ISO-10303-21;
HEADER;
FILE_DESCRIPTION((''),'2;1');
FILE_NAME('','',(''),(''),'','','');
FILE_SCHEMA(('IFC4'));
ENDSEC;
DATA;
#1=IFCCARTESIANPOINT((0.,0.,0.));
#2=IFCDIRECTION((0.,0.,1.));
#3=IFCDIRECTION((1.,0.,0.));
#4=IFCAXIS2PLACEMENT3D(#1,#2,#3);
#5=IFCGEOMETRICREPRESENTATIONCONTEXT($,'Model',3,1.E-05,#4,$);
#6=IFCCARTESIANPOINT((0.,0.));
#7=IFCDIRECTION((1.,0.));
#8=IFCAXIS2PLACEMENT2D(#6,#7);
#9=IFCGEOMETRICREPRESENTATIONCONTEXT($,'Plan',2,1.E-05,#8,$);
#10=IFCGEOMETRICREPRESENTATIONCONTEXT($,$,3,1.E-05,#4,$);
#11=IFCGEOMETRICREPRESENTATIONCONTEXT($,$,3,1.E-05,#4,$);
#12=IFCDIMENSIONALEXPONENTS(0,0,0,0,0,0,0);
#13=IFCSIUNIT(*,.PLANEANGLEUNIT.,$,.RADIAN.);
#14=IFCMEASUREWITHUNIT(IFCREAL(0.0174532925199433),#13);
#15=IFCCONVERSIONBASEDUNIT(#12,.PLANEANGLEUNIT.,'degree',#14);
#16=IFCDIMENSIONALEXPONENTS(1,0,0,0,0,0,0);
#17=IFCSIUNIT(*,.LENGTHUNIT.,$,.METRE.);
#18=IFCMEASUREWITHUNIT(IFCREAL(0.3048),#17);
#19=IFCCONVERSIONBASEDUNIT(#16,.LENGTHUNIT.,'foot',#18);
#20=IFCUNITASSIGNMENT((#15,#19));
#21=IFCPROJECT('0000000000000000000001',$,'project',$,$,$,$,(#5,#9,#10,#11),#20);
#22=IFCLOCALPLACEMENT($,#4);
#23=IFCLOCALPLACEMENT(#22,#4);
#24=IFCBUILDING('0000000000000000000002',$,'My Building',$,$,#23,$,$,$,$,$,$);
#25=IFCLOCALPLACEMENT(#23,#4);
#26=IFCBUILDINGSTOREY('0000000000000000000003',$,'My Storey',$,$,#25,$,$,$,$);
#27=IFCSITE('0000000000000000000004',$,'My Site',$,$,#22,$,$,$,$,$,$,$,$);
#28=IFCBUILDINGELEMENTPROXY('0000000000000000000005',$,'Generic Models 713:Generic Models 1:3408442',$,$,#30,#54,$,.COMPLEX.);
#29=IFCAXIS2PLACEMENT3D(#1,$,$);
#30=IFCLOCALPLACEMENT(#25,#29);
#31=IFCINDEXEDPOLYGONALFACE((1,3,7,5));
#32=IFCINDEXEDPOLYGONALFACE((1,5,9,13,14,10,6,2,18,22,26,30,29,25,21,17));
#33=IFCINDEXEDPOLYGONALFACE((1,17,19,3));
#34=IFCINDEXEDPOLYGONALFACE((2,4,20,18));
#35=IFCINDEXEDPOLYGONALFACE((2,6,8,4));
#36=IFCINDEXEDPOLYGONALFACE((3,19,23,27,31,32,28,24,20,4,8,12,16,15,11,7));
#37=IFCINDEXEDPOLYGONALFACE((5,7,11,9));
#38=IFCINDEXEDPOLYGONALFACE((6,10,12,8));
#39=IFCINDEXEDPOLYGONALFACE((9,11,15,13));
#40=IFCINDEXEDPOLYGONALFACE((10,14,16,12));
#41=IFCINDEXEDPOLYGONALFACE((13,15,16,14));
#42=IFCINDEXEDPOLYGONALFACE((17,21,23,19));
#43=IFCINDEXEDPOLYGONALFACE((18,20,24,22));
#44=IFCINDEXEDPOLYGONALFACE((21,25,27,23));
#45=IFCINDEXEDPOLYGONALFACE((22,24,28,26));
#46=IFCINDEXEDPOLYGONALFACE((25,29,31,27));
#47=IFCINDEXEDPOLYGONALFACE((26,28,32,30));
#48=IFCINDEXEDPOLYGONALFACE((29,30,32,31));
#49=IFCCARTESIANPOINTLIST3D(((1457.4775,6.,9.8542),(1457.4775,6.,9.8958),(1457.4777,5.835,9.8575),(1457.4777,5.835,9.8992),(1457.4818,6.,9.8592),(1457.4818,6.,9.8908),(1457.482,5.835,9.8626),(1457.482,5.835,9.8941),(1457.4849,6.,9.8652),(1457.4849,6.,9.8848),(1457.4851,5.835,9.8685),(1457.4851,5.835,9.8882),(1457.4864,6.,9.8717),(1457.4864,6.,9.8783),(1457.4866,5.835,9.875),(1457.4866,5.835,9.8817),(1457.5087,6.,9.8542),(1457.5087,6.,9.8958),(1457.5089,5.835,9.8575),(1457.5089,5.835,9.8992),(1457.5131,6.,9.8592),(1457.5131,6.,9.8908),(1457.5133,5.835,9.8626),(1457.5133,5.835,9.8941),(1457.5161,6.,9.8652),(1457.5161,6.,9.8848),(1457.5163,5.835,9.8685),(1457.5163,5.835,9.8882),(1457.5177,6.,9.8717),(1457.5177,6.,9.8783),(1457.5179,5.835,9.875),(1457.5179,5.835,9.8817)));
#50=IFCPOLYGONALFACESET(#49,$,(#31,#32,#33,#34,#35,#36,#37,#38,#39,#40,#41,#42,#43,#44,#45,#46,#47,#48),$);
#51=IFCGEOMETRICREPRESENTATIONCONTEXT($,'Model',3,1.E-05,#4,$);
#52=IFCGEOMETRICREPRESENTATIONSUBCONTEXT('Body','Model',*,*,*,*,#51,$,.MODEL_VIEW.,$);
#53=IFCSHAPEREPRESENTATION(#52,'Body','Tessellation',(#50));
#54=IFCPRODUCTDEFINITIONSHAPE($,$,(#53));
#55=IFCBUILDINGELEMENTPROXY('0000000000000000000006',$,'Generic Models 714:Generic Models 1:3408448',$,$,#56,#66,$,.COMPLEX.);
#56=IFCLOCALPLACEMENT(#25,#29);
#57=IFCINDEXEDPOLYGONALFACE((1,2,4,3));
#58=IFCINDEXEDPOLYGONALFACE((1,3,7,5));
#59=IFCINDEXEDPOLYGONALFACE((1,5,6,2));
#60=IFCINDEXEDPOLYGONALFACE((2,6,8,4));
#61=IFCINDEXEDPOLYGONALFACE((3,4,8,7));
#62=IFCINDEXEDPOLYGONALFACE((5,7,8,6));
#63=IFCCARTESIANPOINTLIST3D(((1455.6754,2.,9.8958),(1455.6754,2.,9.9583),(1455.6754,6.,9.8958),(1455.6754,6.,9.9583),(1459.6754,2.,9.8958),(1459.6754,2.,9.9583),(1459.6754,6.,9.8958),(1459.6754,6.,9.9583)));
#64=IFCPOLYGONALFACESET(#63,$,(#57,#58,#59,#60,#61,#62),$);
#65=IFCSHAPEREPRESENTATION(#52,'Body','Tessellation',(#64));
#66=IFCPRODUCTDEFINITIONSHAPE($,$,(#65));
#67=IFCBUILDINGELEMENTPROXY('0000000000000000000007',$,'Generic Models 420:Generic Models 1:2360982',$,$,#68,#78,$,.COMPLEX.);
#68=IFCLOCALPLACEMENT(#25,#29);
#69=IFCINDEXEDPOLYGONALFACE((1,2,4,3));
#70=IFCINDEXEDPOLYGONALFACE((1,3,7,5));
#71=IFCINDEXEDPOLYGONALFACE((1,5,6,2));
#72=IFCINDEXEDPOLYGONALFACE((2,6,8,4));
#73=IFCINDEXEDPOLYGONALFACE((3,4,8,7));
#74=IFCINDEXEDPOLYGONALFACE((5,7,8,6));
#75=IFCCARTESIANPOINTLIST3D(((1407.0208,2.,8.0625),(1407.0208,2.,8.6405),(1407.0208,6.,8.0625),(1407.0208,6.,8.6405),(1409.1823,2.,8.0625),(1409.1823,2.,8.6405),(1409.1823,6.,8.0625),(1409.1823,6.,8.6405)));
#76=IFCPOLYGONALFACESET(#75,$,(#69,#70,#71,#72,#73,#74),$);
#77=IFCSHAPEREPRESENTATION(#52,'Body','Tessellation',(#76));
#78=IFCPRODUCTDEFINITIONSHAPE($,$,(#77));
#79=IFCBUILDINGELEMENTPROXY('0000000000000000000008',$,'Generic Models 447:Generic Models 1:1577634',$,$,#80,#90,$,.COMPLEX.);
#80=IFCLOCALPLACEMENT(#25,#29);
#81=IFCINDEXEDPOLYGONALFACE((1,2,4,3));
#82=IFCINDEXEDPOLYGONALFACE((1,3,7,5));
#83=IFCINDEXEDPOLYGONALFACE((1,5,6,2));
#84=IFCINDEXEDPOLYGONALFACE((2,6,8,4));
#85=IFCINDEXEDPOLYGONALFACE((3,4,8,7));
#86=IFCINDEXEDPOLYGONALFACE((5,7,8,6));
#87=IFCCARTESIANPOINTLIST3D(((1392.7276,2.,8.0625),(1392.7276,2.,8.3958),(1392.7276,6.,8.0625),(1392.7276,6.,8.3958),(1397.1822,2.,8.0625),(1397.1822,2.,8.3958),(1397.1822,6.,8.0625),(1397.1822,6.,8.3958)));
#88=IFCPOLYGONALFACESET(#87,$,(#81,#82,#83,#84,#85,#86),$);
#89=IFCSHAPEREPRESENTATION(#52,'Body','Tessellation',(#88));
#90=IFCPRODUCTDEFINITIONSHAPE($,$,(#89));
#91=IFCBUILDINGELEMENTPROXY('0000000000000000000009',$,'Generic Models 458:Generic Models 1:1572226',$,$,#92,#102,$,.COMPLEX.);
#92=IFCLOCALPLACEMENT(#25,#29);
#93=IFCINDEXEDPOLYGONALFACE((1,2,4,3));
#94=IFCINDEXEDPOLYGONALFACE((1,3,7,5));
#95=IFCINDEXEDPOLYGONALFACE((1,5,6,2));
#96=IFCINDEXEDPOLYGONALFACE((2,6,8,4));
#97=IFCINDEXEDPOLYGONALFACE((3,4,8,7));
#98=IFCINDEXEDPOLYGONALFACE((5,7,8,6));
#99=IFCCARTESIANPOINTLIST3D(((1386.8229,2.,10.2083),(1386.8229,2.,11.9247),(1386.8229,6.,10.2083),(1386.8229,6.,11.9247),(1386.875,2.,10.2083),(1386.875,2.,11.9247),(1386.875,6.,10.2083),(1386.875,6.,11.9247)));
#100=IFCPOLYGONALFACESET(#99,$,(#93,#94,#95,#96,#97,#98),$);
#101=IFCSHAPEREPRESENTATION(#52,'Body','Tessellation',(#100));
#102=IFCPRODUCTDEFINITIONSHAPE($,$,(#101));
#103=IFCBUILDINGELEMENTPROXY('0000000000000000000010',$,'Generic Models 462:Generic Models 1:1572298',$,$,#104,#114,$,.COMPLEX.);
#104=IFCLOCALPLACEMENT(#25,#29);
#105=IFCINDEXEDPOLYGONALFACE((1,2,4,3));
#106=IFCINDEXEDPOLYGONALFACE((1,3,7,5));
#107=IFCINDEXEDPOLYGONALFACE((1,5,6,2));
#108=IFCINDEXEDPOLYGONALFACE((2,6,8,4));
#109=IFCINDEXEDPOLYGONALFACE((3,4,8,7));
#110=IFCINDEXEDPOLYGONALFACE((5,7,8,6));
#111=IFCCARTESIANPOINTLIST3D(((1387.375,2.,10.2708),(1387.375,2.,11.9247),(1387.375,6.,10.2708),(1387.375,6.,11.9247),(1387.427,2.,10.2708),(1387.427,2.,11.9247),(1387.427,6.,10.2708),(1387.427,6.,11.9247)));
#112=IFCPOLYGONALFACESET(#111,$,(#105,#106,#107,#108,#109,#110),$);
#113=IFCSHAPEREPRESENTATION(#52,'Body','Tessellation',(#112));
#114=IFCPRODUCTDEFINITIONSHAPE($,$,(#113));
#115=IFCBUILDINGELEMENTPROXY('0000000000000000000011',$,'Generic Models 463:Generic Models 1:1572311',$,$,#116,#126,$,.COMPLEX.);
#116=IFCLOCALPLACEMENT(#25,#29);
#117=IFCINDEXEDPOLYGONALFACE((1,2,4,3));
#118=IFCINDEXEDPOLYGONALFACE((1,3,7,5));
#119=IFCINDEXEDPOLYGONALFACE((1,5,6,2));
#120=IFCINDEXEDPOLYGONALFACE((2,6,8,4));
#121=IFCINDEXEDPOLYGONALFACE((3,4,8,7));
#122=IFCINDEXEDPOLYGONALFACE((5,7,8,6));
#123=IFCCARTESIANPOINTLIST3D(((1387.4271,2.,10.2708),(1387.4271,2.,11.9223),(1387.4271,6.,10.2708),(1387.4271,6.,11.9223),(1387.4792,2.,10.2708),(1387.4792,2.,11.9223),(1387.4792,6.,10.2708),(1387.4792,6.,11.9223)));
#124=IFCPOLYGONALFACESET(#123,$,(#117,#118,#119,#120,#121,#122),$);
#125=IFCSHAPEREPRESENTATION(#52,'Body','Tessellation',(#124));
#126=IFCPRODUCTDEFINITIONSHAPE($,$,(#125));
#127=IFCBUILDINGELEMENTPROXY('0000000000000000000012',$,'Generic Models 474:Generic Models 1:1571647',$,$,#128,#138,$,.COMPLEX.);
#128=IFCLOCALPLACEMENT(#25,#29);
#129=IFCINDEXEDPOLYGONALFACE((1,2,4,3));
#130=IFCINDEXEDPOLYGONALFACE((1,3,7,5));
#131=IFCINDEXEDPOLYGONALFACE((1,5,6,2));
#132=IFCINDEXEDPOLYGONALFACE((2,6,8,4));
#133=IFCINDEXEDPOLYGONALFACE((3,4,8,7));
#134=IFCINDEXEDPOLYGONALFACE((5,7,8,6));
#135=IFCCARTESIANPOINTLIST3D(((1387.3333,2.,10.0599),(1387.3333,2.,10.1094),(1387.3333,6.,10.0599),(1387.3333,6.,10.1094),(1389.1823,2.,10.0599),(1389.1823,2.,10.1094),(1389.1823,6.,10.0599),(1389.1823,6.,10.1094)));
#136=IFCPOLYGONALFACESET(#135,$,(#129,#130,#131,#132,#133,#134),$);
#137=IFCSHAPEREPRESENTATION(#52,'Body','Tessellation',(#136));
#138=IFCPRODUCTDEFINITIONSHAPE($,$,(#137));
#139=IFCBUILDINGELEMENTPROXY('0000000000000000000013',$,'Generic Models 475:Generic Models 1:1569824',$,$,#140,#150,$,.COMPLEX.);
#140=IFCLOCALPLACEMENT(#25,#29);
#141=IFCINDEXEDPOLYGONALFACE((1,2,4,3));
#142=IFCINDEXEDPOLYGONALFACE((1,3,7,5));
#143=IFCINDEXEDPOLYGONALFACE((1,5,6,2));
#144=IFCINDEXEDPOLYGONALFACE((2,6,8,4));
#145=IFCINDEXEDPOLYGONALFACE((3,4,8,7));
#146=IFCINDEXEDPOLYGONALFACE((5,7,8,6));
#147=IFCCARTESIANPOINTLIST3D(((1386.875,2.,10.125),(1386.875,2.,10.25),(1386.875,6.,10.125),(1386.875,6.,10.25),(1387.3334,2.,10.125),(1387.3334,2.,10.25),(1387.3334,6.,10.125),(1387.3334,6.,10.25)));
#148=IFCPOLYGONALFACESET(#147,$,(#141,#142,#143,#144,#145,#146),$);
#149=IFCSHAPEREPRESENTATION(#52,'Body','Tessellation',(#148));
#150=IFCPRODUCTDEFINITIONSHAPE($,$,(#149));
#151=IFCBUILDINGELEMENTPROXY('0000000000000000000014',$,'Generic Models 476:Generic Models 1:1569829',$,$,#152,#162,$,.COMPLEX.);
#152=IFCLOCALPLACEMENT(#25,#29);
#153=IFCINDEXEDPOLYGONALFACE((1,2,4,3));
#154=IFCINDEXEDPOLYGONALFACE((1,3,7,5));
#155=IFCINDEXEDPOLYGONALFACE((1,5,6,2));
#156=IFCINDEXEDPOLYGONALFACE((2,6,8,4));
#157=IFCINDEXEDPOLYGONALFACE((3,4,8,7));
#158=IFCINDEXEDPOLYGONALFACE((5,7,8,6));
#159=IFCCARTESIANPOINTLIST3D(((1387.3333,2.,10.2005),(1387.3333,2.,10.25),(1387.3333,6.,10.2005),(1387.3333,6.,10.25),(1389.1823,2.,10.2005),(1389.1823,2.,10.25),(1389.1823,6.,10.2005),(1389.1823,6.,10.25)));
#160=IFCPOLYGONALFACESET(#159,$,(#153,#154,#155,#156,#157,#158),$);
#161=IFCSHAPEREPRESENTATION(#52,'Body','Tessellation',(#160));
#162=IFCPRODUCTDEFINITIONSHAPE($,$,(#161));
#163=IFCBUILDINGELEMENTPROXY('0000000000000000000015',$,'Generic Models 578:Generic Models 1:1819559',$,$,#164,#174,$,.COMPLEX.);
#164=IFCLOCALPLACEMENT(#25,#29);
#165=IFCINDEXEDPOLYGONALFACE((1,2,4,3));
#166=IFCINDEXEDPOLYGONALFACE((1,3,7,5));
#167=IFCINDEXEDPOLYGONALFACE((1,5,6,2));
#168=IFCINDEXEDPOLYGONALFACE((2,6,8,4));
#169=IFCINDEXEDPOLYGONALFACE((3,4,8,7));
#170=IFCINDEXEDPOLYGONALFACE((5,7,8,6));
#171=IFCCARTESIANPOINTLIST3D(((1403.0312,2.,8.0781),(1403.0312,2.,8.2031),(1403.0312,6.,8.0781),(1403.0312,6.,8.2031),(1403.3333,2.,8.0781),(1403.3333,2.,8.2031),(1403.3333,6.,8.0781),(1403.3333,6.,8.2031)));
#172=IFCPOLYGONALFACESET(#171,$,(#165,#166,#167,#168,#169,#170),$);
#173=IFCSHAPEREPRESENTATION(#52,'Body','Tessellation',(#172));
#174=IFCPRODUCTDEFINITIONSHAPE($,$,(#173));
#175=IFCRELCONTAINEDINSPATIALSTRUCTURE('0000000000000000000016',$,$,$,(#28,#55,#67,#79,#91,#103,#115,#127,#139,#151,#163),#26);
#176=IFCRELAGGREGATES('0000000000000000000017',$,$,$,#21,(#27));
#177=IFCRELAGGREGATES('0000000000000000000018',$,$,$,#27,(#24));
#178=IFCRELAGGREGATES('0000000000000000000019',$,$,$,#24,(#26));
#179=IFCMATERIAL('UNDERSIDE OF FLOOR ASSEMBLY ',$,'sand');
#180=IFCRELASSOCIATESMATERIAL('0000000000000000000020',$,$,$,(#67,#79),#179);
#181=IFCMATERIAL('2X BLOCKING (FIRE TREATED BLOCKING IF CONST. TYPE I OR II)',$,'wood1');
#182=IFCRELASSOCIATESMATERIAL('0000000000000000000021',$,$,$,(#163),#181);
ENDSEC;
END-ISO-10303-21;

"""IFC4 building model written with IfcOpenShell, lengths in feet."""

from ifc_helpers import new_model, entity, si_unit, converted_unit, frame, origin_with_axes, origin_2d_with_axis, place, context, subcontext, project, spatial, polyline, line, indexed_curve, outline, extrude, material, element, save


model = new_model("IFC4")

# Units and contexts
model_context_1 = context("Model", 3, precision=1e-05, world=origin_with_axes())
plan_context = context("Plan", 2, precision=1e-05, world=origin_2d_with_axis())
model_context_2 = context("Model", 3, precision=1e-05, world=origin_with_axes())
context_of_model_1 = context(None, 3, precision=1e-05, world=origin_with_axes())
context_of_model_2 = context(None, 3, precision=1e-05, world=origin_with_axes())
body_context_1 = subcontext(model_context_2, "Body", "Model", "MODEL_VIEW")
ifc_project = project(units=[converted_unit("PLANEANGLEUNIT", "degree", entity("IfcReal", 0.0174532925199433), si_unit("PLANEANGLEUNIT", "RADIAN"), dimensions=[0, 0, 0, 0, 0, 0, 0]), converted_unit("LENGTHUNIT", "foot", entity("IfcReal", 0.3048), si_unit("LENGTHUNIT", "METRE"), dimensions=[1, 0, 0, 0, 0, 0, 0])], contexts=[model_context_1, plan_context, context_of_model_1, context_of_model_2])

# Site, building, storey
site_placement = place(None, origin_with_axes())
site = spatial("IfcSite", under=ifc_project, at=site_placement, Name="My Site")
building_placement = place(site_placement, origin_with_axes())
building = spatial("IfcBuilding", under=site, at=building_placement, Name="My Building")
storey_placement = place(building_placement, origin_with_axes())
storey = spatial("IfcBuildingStorey", under=building, at=storey_placement, Name="My Storey")

# Building element proxies
ifc_material_1 = material(Name="UNDERSIDE OF FLOOR ASSEMBLY ", Category="sand")
proxy_1_placement = place(storey_placement, frame((1457.4775, 6.0, 9.8542), z_axis=(0.0, -1.0, 0.0), x_axis=(0.0, 0.0, 1.0)))
element("IfcBuildingElementProxy", 1, at=proxy_1_placement, inside=storey, Name="Generic Models 713:Generic Models 1:3408442", PredefinedType="COMPLEX", context=body_context_1, shape_type="SweptSolid", body=[
    extrude(outline(polyline([(0.0166, 0.0), (0.0226, 0.003), (0.0291, 0.0045), (0.0039, 0.023), (-0.0026, 0.0215), (-0.0086, 0.0185), (-0.0137, 0.0142), (-0.0176, 0.0088), (-0.0202, 0.0026), (-0.0213, -0.004), (-0.0207, -0.0106), (0.0045, -0.0291), (0.0039, -0.0224), (0.005, -0.0159), (0.0076, -0.0097), (0.0115, -0.0043), (0.0166, 0.0)])), frame((0.0208, -0.0208, 0.0), z_axis=(0.0, 0.0, -1.0), x_axis=(0.591192, 0.806531, 0.0)), (0.010994, 0.017024, -0.999795), 0.165),
])
proxy_2_placement = place(storey_placement, frame((1455.6754, 6.0, 9.8958), z_axis=(0.0, -1.0, 0.0), x_axis=(0.0, 0.0, 1.0)))
element("IfcBuildingElementProxy", 2, at=proxy_2_placement, inside=storey, Name="Generic Models 714:Generic Models 1:3408448", PredefinedType="COMPLEX", context=body_context_1, shape_type="SweptSolid", body=[
    extrude(outline(indexed_curve([(-0.0313, -2.0), (0.0312, -2.0), (0.0313, 2.0), (-0.0312, 2.0)], segments=[line(4, 1), line(1, 2), line(2, 3), line(3, 4)], self_intersect=False)), frame((0.0313, -2.0, 0.0), z_axis=(0.0, 0.0, -1.0), x_axis=(-1.0, 0.0, 0.0)), (0.0, 0.0, -1.0), 4.0),
])
proxy_3_placement = place(storey_placement, frame((1407.0208, 6.0, 8.0625), z_axis=(0.0, -1.0, 0.0), x_axis=(0.0, 0.0, 1.0)))
element("IfcBuildingElementProxy", 3, at=proxy_3_placement, inside=storey, material=ifc_material_1, Name="Generic Models 420:Generic Models 1:2360982", PredefinedType="COMPLEX", context=body_context_1, shape_type="SweptSolid", body=[
    extrude(outline(polyline([(-0.289, -1.0807), (0.289, -1.0807), (0.289, 1.0807), (-0.289, 1.0807), (-0.289, -1.0807)])), frame((0.289, -1.0807, 0.0), z_axis=(0.0, 0.0, -1.0), x_axis=(1.0, 0.0, 0.0)), (0.0, 0.0, -1.0), 4.0),
])
proxy_4_placement = place(storey_placement, frame((1392.7276, 6.0, 8.0625), z_axis=(0.0, -1.0, 0.0), x_axis=(0.0, 0.0, 1.0)))
element("IfcBuildingElementProxy", 4, at=proxy_4_placement, inside=storey, material=ifc_material_1, Name="Generic Models 447:Generic Models 1:1577634", PredefinedType="COMPLEX", context=body_context_1, shape_type="SweptSolid", body=[
    extrude(outline(indexed_curve([(-2.4546, -0.1667), (2.0, -0.1667), (2.0, 0.1667), (-2.4546, 0.1667)], segments=[line(3, 2), line(2, 1), line(1, 4), line(4, 3)], self_intersect=False)), frame((0.1667, -2.0, 0.0), z_axis=(0.0, 0.0, -1.0), x_axis=(0.0, 1.0, 0.0)), (0.0, 0.0, -1.0), 4.0),
])
proxy_5_placement = place(storey_placement, frame((1386.8229, 6.0, 10.2083), z_axis=(0.0, -1.0, 0.0), x_axis=(0.0, 0.0, 1.0)))
element("IfcBuildingElementProxy", 5, at=proxy_5_placement, inside=storey, Name="Generic Models 458:Generic Models 1:1572226", PredefinedType="COMPLEX", context=body_context_1, shape_type="SweptSolid", body=[
    extrude(outline(polyline([(-0.8582, -0.026), (0.8582, -0.026), (0.8582, 0.026), (-0.8582, 0.026), (-0.8582, -0.026)])), frame((0.8582, -0.026, 0.0), z_axis=(0.0, 0.0, -1.0), x_axis=(1.0, 0.0, 0.0)), (0.0, 0.0, -1.0), 4.0),
])
proxy_6_placement = place(storey_placement, frame((1387.375, 6.0, 10.2708), z_axis=(0.0, -1.0, 0.0), x_axis=(0.0, 0.0, 1.0)))
element("IfcBuildingElementProxy", 6, at=proxy_6_placement, inside=storey, Name="Generic Models 462:Generic Models 1:1572298", PredefinedType="COMPLEX", context=body_context_1, shape_type="SweptSolid", body=[
    extrude(outline(polyline([(-0.026, -0.8269), (0.026, -0.8269), (0.026, 0.8269), (-0.026, 0.8269), (-0.026, -0.8269)])), frame((0.8269, -0.026, 0.0), z_axis=(0.0, 0.0, -1.0), x_axis=(0.0, 1.0, 0.0)), (0.0, 0.0, -1.0), 4.0),
])
proxy_7_placement = place(storey_placement, frame((1387.4271, 6.0, 10.2708), z_axis=(0.0, -1.0, 0.0), x_axis=(0.0, 0.0, 1.0)))
element("IfcBuildingElementProxy", 7, at=proxy_7_placement, inside=storey, Name="Generic Models 463:Generic Models 1:1572311", PredefinedType="COMPLEX", context=body_context_1, shape_type="SweptSolid", body=[
    extrude(outline(polyline([(-0.026, -0.8258), (0.026, -0.8258), (0.026, 0.8258), (-0.026, 0.8258), (-0.026, -0.8258)])), frame((0.8258, -0.026, 0.0), z_axis=(0.0, 0.0, -1.0), x_axis=(0.0, 1.0, 0.0)), (0.0, 0.0, -1.0), 4.0),
])
proxy_8_placement = place(storey_placement, frame((1387.3333, 6.0, 10.0599), z_axis=(0.0, -1.0, 0.0), x_axis=(0.0, 0.0, 1.0)))
element("IfcBuildingElementProxy", 8, at=proxy_8_placement, inside=storey, Name="Generic Models 474:Generic Models 1:1571647", PredefinedType="COMPLEX", context=body_context_1, shape_type="SweptSolid", body=[
    extrude(outline(polyline([(-0.0247, -0.9245), (0.0247, -0.9245), (0.0247, 0.9245), (-0.0247, 0.9245), (-0.0247, -0.9245)])), frame((0.0247, -0.9245, 0.0), z_axis=(0.0, 0.0, -1.0), x_axis=(-1.0, 0.0, 0.0)), (0.0, 0.0, -1.0), 4.0),
])
proxy_9_placement = place(storey_placement, frame((1386.875, 6.0, 10.125), z_axis=(0.0, -1.0, 0.0), x_axis=(0.0, 0.0, 1.0)))
element("IfcBuildingElementProxy", 9, at=proxy_9_placement, inside=storey, Name="Generic Models 475:Generic Models 1:1569824", PredefinedType="COMPLEX", context=body_context_1, shape_type="SweptSolid", body=[
    extrude(outline(polyline([(-0.2292, -0.0625), (0.2292, -0.0625), (0.2292, 0.0625), (-0.2292, 0.0625), (-0.2292, -0.0625)])), frame((0.0625, -0.2292, 0.0), z_axis=(0.0, 0.0, -1.0), x_axis=(0.0, 1.0, 0.0)), (0.0, 0.0, -1.0), 4.0),
])
proxy_10_placement = place(storey_placement, frame((1387.3333, 6.0, 10.2005), z_axis=(0.0, -1.0, 0.0), x_axis=(0.0, 0.0, 1.0)))
element("IfcBuildingElementProxy", 10, at=proxy_10_placement, inside=storey, Name="Generic Models 476:Generic Models 1:1569829", PredefinedType="COMPLEX", context=body_context_1, shape_type="SweptSolid", body=[
    extrude(outline(polyline([(-0.0247, -0.9245), (0.0247, -0.9245), (0.0247, 0.9245), (-0.0247, 0.9245), (-0.0247, -0.9245)])), frame((0.0247, -0.9245, 0.0), z_axis=(0.0, 0.0, -1.0), x_axis=(-1.0, 0.0, 0.0)), (0.0, 0.0, -1.0), 4.0),
])
ifc_material_2 = material(Name="2X BLOCKING (FIRE TREATED BLOCKING IF CONST. TYPE I OR II)", Category="wood1")
proxy_11_placement = place(storey_placement, frame((1403.0312, 6.0, 8.0781), z_axis=(0.0, -1.0, 0.0), x_axis=(0.0, 0.0, 1.0)))
element("IfcBuildingElementProxy", 11, at=proxy_11_placement, inside=storey, material=ifc_material_2, Name="Generic Models 578:Generic Models 1:1819559", PredefinedType="COMPLEX", context=body_context_1, shape_type="SweptSolid", body=[
    extrude(outline(polyline([(-0.0625, -0.151), (0.0625, -0.151), (0.0625, 0.151), (-0.0625, 0.151), (-0.0625, -0.151)])), frame((0.0625, -0.151, 0.0), z_axis=(0.0, 0.0, -1.0), x_axis=(-1.0, 0.0, 0.0)), (0.0, 0.0, -1.0), 4.0),
])

save(model, "model.ifc")
